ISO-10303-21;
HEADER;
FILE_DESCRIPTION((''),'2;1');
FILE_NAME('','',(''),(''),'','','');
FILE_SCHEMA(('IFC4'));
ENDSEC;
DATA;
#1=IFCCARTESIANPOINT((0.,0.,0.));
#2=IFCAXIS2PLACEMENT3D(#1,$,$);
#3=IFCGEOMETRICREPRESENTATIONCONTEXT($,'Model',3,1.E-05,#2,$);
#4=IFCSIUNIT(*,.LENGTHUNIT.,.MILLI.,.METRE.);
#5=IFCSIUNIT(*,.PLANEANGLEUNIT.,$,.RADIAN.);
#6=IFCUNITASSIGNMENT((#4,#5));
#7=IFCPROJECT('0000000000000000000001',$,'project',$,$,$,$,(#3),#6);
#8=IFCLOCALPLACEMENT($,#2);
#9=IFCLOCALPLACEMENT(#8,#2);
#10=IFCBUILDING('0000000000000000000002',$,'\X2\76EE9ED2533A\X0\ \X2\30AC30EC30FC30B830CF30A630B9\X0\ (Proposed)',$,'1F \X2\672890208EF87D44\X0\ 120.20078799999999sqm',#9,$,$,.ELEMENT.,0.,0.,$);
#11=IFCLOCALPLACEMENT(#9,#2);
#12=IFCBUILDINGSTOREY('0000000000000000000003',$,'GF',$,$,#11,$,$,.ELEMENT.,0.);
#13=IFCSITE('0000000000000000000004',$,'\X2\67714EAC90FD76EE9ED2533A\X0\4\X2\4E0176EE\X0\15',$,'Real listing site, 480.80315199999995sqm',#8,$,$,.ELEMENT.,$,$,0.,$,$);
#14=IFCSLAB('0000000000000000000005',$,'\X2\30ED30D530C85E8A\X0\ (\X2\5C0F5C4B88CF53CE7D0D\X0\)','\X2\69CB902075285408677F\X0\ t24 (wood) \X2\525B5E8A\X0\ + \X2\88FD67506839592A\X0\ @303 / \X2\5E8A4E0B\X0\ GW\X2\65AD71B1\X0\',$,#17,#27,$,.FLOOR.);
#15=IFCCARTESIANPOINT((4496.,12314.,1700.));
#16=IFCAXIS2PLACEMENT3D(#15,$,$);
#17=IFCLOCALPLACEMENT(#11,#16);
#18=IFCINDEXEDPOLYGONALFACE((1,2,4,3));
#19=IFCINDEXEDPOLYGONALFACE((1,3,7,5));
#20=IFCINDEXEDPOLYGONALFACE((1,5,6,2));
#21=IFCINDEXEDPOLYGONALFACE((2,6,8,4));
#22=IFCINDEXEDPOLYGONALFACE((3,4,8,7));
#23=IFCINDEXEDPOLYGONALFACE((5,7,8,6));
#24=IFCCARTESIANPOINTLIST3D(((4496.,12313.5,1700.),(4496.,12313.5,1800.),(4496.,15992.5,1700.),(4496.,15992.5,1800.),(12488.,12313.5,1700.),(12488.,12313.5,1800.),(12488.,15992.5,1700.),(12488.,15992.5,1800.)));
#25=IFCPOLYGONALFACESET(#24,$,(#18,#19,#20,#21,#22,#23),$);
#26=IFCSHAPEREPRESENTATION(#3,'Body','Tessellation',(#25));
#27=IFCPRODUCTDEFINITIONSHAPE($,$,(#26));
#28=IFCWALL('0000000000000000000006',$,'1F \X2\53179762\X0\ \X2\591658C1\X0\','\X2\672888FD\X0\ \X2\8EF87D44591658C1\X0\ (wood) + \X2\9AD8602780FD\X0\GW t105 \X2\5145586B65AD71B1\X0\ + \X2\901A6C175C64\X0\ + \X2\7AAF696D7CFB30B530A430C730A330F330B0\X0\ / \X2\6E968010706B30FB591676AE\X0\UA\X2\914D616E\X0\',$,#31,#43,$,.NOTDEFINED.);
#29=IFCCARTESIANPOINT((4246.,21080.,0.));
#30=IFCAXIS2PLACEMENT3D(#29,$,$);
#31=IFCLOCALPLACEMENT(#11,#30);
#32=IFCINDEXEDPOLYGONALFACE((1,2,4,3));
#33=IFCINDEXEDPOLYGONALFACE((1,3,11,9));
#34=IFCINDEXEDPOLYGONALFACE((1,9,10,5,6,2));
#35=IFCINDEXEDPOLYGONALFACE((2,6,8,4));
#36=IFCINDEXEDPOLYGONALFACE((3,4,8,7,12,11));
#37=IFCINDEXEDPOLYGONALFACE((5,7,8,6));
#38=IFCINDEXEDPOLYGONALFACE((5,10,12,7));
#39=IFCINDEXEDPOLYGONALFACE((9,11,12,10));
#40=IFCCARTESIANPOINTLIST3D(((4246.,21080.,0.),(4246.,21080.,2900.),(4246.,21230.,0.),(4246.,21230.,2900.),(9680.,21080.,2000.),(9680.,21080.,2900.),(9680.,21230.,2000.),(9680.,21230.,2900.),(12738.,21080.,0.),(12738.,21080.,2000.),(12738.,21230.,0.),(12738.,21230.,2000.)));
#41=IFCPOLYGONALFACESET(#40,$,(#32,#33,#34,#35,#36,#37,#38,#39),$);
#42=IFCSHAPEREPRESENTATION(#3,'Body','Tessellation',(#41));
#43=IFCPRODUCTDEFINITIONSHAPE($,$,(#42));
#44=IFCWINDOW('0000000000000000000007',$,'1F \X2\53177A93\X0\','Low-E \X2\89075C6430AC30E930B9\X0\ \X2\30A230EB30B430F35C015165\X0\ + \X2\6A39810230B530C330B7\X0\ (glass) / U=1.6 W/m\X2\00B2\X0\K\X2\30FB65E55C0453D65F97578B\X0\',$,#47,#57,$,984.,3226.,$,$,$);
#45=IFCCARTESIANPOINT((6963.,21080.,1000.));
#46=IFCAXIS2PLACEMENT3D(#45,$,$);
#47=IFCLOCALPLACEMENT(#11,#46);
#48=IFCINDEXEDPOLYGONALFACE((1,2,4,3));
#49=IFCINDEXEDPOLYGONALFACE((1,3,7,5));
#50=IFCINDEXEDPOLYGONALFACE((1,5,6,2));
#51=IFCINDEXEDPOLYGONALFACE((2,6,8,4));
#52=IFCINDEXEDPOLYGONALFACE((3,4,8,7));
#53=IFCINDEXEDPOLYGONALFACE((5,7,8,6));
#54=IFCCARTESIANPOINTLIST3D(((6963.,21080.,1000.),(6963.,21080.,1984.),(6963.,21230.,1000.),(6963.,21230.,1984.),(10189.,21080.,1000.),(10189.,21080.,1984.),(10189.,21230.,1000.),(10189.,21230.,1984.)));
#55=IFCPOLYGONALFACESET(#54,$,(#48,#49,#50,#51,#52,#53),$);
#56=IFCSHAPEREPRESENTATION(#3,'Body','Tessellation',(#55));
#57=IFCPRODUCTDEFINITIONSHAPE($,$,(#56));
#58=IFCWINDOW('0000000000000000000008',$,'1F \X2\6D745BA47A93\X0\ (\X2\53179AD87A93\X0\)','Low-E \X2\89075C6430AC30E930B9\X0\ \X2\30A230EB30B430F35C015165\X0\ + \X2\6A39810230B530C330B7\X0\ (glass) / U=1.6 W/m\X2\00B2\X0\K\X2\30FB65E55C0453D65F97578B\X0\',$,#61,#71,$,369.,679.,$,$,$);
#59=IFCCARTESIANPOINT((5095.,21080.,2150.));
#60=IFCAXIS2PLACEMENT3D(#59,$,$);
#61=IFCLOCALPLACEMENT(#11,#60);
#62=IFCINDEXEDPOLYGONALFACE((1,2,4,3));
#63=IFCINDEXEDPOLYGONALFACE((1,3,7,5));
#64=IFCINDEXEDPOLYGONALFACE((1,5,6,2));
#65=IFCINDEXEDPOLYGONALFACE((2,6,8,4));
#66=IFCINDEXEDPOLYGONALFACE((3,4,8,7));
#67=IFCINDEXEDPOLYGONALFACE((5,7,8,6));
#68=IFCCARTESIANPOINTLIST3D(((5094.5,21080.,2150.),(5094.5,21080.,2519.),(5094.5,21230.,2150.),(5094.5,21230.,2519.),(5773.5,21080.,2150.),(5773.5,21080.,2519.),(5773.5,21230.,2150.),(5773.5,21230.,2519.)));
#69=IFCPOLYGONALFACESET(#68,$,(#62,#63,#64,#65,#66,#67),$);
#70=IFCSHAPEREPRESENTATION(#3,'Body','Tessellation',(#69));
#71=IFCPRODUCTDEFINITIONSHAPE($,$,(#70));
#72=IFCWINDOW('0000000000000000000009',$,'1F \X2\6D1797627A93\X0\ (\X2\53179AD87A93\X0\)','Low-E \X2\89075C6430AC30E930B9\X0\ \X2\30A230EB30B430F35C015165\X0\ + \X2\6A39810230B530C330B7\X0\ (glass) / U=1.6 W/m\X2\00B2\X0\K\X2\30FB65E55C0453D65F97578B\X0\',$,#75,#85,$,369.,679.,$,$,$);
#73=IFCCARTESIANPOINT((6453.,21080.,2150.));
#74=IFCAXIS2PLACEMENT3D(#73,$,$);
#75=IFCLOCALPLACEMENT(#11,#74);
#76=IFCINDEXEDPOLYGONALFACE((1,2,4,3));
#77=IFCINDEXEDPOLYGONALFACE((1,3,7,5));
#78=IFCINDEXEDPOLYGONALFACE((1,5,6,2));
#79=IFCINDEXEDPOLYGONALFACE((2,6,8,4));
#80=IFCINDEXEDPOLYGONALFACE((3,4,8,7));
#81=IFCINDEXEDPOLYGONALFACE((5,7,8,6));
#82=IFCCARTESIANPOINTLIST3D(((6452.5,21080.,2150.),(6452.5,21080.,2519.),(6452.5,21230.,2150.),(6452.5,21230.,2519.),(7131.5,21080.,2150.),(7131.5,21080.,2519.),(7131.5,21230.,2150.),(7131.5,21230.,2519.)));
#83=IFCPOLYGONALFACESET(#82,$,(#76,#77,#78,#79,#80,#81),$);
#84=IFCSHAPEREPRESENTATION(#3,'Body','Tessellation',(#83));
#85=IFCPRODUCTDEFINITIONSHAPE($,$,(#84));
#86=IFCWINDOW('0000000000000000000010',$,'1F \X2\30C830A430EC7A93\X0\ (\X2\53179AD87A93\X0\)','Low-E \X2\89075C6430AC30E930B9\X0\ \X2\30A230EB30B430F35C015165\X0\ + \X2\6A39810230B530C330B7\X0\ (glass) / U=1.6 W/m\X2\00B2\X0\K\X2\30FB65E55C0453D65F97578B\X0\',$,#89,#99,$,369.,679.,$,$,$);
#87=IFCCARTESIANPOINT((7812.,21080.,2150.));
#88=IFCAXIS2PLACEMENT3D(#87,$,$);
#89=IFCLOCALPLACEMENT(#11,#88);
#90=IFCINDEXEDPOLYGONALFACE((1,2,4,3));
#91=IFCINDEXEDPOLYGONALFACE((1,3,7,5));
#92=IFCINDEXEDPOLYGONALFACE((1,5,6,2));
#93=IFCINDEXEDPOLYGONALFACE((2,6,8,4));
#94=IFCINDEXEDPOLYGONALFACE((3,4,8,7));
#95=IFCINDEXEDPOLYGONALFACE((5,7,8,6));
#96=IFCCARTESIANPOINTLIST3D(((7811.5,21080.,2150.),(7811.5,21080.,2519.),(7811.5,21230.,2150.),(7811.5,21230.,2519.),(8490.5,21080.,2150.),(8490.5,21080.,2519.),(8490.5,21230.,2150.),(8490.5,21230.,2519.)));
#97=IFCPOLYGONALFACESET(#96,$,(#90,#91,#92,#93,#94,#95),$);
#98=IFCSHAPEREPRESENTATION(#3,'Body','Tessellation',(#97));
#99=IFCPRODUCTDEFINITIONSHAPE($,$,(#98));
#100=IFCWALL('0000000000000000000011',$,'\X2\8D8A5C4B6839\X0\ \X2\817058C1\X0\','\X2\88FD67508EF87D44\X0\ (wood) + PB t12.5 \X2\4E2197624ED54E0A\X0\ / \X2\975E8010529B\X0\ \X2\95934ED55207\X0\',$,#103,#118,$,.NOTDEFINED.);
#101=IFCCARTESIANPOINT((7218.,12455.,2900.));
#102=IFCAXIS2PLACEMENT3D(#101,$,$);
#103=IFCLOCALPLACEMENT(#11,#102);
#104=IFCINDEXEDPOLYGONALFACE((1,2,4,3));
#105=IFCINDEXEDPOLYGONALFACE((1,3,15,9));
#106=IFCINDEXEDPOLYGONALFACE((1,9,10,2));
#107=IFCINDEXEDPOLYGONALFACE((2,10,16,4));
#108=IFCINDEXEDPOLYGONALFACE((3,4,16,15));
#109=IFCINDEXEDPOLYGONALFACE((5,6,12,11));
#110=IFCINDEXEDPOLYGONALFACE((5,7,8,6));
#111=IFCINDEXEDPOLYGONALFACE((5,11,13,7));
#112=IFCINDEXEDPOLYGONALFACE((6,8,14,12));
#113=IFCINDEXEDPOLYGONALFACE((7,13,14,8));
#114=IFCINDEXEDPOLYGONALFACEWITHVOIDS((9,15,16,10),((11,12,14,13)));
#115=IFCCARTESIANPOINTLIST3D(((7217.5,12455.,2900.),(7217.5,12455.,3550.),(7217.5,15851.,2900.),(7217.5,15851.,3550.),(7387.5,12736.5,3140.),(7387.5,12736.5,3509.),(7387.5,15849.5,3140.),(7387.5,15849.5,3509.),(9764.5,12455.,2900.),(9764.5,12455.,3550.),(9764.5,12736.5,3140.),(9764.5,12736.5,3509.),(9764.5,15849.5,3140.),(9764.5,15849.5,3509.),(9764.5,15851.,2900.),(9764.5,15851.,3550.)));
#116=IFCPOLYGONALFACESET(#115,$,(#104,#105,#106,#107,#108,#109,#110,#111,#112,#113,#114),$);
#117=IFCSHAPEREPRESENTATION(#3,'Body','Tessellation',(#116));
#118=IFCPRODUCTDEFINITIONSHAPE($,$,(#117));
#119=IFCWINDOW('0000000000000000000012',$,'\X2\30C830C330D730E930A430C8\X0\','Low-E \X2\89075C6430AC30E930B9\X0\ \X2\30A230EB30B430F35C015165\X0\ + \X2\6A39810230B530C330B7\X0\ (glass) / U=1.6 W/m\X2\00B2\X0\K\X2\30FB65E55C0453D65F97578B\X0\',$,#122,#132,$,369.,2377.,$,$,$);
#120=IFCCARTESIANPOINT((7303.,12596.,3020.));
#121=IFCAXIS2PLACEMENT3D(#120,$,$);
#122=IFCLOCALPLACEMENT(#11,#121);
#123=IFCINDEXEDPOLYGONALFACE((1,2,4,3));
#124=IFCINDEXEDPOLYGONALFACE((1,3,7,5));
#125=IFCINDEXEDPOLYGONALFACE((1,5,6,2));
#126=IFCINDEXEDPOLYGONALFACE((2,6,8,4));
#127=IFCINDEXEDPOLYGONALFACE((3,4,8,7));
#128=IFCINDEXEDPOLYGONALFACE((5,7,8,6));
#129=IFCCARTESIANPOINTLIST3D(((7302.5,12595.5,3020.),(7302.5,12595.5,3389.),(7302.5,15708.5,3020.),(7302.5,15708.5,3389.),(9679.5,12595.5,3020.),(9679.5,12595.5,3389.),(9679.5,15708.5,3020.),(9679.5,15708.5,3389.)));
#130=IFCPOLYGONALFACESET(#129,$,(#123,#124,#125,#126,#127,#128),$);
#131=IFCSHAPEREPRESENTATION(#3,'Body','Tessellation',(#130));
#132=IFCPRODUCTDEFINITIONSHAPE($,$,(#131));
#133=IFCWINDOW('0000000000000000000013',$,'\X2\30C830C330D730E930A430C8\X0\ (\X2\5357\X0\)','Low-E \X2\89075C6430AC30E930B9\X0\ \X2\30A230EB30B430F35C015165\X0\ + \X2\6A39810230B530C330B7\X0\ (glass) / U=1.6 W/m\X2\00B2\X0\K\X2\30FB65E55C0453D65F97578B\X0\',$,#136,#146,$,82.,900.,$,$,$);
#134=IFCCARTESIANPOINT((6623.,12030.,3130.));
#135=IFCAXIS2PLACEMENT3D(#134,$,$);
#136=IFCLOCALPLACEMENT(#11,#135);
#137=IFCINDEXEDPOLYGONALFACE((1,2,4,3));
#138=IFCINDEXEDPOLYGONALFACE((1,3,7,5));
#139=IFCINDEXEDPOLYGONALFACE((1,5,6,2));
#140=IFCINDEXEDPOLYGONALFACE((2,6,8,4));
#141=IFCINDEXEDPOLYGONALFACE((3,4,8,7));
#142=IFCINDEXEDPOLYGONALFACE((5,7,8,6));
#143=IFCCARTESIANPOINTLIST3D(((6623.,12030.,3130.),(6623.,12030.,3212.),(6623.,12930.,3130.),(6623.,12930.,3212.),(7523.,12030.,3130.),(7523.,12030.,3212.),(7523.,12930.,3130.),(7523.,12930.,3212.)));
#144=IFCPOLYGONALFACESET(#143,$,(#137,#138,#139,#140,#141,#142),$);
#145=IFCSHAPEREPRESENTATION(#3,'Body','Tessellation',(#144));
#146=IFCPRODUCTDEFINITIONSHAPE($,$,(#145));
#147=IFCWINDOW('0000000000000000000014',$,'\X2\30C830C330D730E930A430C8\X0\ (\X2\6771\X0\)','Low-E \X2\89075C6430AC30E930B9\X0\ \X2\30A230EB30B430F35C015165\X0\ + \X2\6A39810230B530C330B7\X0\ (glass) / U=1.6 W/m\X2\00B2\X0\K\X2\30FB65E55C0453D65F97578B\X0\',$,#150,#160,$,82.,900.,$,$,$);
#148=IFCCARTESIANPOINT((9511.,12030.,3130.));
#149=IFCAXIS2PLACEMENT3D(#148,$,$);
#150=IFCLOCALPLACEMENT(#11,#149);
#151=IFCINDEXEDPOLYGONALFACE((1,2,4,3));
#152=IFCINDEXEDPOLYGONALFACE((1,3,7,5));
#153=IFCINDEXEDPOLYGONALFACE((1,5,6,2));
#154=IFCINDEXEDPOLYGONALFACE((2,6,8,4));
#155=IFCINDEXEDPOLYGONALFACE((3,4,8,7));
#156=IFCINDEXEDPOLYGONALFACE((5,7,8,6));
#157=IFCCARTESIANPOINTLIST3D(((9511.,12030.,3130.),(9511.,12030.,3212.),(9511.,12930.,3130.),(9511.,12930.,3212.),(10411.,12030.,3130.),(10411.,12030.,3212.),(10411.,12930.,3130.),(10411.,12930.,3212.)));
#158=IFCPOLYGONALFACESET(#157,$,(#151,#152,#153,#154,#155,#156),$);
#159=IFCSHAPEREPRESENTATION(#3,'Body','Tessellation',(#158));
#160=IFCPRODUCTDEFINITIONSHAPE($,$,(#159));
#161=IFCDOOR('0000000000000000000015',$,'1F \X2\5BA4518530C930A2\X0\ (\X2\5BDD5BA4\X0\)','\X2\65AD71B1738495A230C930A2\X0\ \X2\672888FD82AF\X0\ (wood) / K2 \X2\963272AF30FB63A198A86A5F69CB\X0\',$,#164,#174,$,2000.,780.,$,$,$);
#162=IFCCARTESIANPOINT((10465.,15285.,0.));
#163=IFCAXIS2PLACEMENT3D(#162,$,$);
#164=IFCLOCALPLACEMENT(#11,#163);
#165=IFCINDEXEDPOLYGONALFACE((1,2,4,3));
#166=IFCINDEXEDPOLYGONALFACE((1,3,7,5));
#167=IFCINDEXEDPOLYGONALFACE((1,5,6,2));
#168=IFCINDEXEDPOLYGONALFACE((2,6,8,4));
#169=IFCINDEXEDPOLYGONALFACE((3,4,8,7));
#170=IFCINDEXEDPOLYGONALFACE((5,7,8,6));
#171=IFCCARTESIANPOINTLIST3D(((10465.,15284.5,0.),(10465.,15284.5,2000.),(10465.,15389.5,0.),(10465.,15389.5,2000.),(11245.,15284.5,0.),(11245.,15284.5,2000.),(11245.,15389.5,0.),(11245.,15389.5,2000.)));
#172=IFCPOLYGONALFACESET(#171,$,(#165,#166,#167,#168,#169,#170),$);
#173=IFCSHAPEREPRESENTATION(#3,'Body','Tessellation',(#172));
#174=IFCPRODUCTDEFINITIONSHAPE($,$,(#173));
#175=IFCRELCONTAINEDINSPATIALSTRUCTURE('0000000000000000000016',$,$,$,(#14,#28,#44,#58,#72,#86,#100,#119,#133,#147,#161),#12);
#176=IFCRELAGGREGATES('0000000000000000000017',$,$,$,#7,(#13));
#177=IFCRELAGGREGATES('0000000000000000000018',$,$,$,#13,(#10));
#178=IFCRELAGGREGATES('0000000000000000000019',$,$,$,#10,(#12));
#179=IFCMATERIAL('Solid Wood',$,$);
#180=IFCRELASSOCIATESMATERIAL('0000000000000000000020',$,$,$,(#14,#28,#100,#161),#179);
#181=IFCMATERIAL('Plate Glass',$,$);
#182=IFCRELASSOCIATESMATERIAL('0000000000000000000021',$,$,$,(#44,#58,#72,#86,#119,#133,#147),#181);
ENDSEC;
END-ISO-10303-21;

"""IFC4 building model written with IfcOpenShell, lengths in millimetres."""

from ifc_helpers import new_model, si_unit, frame, frame_2d, origin, place, context, project, spatial, rectangle, extrude, material, element, fill, save


model = new_model("IFC4")

# Units and contexts
model_context = context("Model", 3, precision=1e-05, world=origin())
ifc_project = project(units=[si_unit("LENGTHUNIT", "METRE", prefix="MILLI"), si_unit("PLANEANGLEUNIT", "RADIAN")], contexts=[model_context])

# Site, building, storey
site_placement = place(None, origin())
site = spatial("IfcSite", under=ifc_project, at=site_placement, Name="東京都目黒区4丁目15", ObjectType="Real listing site, 480.80315199999995sqm", CompositionType="ELEMENT", RefElevation=0.0)
building_placement = place(site_placement, origin())
building = spatial("IfcBuilding", under=site, at=building_placement, Name="目黒区 ガレージハウス (Proposed)", ObjectType="1F 木造軸組 120.20078799999999sqm", CompositionType="ELEMENT", ElevationOfRefHeight=0.0, ElevationOfTerrain=0.0)
storey_placement = place(building_placement, origin())
storey = spatial("IfcBuildingStorey", under=building, at=storey_placement, Name="GF", CompositionType="ELEMENT", Elevation=0.0)

# Slab
ifc_material_1 = material(Name="Solid Wood")
slab_placement = place(storey_placement, frame((4496.0, 12314.0, 1700.0)))
element("IfcSlab", 1, at=slab_placement, inside=storey, material=ifc_material_1, Name="ロフト床 (小屋裏収納)", Description="構造用合板 t24 (wood) 剛床 + 製材根太 @303 / 床下 GW断熱", PredefinedType="FLOOR", context=model_context, shape_type="SweptSolid", body=[
    extrude(rectangle(XDim=7992.0, YDim=3679.0, at=frame_2d((3996.0, 1839.0))), frame((4496.0, 12314.0, 1700.0)), (0.0, 0.0, 1.0), 100.0),
])

# Wall, openings, windows
wall_1_placement = place(storey_placement, frame((4246.0, 21080.0, 0.0)))
wall_1 = element("IfcWall", 2, at=wall_1_placement, inside=storey, material=ifc_material_1, Name="1F 北面 外壁", Description="木製 軸組外壁 (wood) + 高性能GW t105 充填断熱 + 通気層 + 窯業系サイディング / 準耐火・外皮UA配慮", PredefinedType="NOTDEFINED", context=model_context, shape_type="SweptSolid", body=[
    extrude(rectangle(XDim=8492.0, YDim=150.0, at=frame_2d((4246.0, 75.0))), frame((4246.0, 21080.0, 0.0)), (0.0, 0.0, 1.0), 2900.0),
])
opening_1_placement = place(storey_placement, frame((6963.0, 21080.0, 1000.0)))
opening_1 = element("IfcOpeningElement", 3, at=opening_1_placement, cuts=wall_1, PredefinedType="NOTDEFINED", context=model_context, shape_type="SweptSolid", body=[
    extrude(rectangle(XDim=3226.0, YDim=150.0, at=frame_2d((1613.0, 75.0))), frame((6963.0, 21080.0, 1000.0)), (0.0, 0.0, 1.0), 984.0),
])
opening_2_placement = place(storey_placement, frame((5095.0, 21080.0, 2150.0)))
opening_2 = element("IfcOpeningElement", 4, at=opening_2_placement, cuts=wall_1, PredefinedType="NOTDEFINED", context=model_context, shape_type="SweptSolid", body=[
    extrude(rectangle(XDim=679.0, YDim=150.0, at=frame_2d((339.0, 75.0))), frame((5095.0, 21080.0, 2150.0)), (0.0, 0.0, 1.0), 369.0),
])
opening_3_placement = place(storey_placement, frame((6453.0, 21080.0, 2150.0)))
opening_3 = element("IfcOpeningElement", 5, at=opening_3_placement, cuts=wall_1, PredefinedType="NOTDEFINED", context=model_context, shape_type="SweptSolid", body=[
    extrude(rectangle(XDim=679.0, YDim=150.0, at=frame_2d((339.0, 75.0))), frame((6453.0, 21080.0, 2150.0)), (0.0, 0.0, 1.0), 369.0),
])
opening_4_placement = place(storey_placement, frame((7812.0, 21080.0, 2150.0)))
opening_4 = element("IfcOpeningElement", 6, at=opening_4_placement, cuts=wall_1, PredefinedType="NOTDEFINED", context=model_context, shape_type="SweptSolid", body=[
    extrude(rectangle(XDim=679.0, YDim=150.0, at=frame_2d((339.0, 75.0))), frame((7812.0, 21080.0, 2150.0)), (0.0, 0.0, 1.0), 369.0),
])
ifc_material_2 = material(Name="Plate Glass")
window_1_placement = place(storey_placement, frame((6963.0, 21080.0, 1000.0)))
window_1 = element("IfcWindow", 7, at=window_1_placement, inside=storey, material=ifc_material_2, Name="1F 北窓", Description="Low-E 複層ガラス アルゴン封入 + 樹脂サッシ (glass) / U=1.6 W/m²K・日射取得型", OverallHeight=984.0, OverallWidth=3226.0, context=model_context, shape_type="SweptSolid", body=[
    extrude(rectangle(XDim=3226.0, YDim=150.0, at=frame_2d((1613.0, 75.0))), frame((6963.0, 21080.0, 1000.0)), (0.0, 0.0, 1.0), 984.0),
])
fill(opening_1, window_1)
window_2_placement = place(storey_placement, frame((5095.0, 21080.0, 2150.0)))
window_2 = element("IfcWindow", 8, at=window_2_placement, inside=storey, material=ifc_material_2, Name="1F 浴室窓 (北高窓)", Description="Low-E 複層ガラス アルゴン封入 + 樹脂サッシ (glass) / U=1.6 W/m²K・日射取得型", OverallHeight=369.0, OverallWidth=679.0, context=model_context, shape_type="SweptSolid", body=[
    extrude(rectangle(XDim=679.0, YDim=150.0, at=frame_2d((339.0, 75.0))), frame((5095.0, 21080.0, 2150.0)), (0.0, 0.0, 1.0), 369.0),
])
fill(opening_2, window_2)
window_3_placement = place(storey_placement, frame((6453.0, 21080.0, 2150.0)))
window_3 = element("IfcWindow", 9, at=window_3_placement, inside=storey, material=ifc_material_2, Name="1F 洗面窓 (北高窓)", Description="Low-E 複層ガラス アルゴン封入 + 樹脂サッシ (glass) / U=1.6 W/m²K・日射取得型", OverallHeight=369.0, OverallWidth=679.0, context=model_context, shape_type="SweptSolid", body=[
    extrude(rectangle(XDim=679.0, YDim=150.0, at=frame_2d((339.0, 75.0))), frame((6453.0, 21080.0, 2150.0)), (0.0, 0.0, 1.0), 369.0),
])
fill(opening_3, window_3)
window_4_placement = place(storey_placement, frame((7812.0, 21080.0, 2150.0)))
window_4 = element("IfcWindow", 10, at=window_4_placement, inside=storey, material=ifc_material_2, Name="1F トイレ窓 (北高窓)", Description="Low-E 複層ガラス アルゴン封入 + 樹脂サッシ (glass) / U=1.6 W/m²K・日射取得型", OverallHeight=369.0, OverallWidth=679.0, context=model_context, shape_type="SweptSolid", body=[
    extrude(rectangle(XDim=679.0, YDim=150.0, at=frame_2d((339.0, 75.0))), frame((7812.0, 21080.0, 2150.0)), (0.0, 0.0, 1.0), 369.0),
])
fill(opening_4, window_4)

# Wall, openings, windows
wall_2_placement = place(storey_placement, frame((7218.0, 12455.0, 2900.0)))
wall_2 = element("IfcWall", 11, at=wall_2_placement, inside=storey, material=ifc_material_1, Name="越屋根 腰壁", Description="製材軸組 (wood) + PB t12.5 両面仕上 / 非耐力 間仕切", PredefinedType="NOTDEFINED", context=model_context, shape_type="SweptSolid", body=[
    extrude(rectangle(XDim=2547.0, YDim=3396.0, at=frame_2d((1273.0, 1698.0))), frame((7218.0, 12455.0, 2900.0)), (0.0, 0.0, 1.0), 650.0),
])
opening_5_placement = place(storey_placement, frame((7303.0, 12596.0, 3020.0)))
opening_5 = element("IfcOpeningElement", 12, at=opening_5_placement, cuts=wall_2, PredefinedType="NOTDEFINED", context=model_context, shape_type="SweptSolid", body=[
    extrude(rectangle(XDim=2377.0, YDim=3113.0, at=frame_2d((1188.0, 1556.0))), frame((7303.0, 12596.0, 3020.0)), (0.0, 0.0, 1.0), 369.0),
])
opening_6_placement = place(storey_placement, frame((6623.0, 12030.0, 3130.0)))
opening_6 = element("IfcOpeningElement", 13, at=opening_6_placement, cuts=wall_2, PredefinedType="NOTDEFINED", context=model_context, shape_type="SweptSolid", body=[
    extrude(rectangle(XDim=900.0, YDim=900.0, at=frame_2d((450.0, 450.0))), frame((6623.0, 12030.0, 3130.0)), (0.0, 0.0, 1.0), 82.0),
])
opening_7_placement = place(storey_placement, frame((9511.0, 12030.0, 3130.0)))
opening_7 = element("IfcOpeningElement", 14, at=opening_7_placement, cuts=wall_2, PredefinedType="NOTDEFINED", context=model_context, shape_type="SweptSolid", body=[
    extrude(rectangle(XDim=900.0, YDim=900.0, at=frame_2d((450.0, 450.0))), frame((9511.0, 12030.0, 3130.0)), (0.0, 0.0, 1.0), 82.0),
])
window_5_placement = place(storey_placement, frame((7303.0, 12596.0, 3020.0)))
window_5 = element("IfcWindow", 15, at=window_5_placement, inside=storey, material=ifc_material_2, Name="トップライト", Description="Low-E 複層ガラス アルゴン封入 + 樹脂サッシ (glass) / U=1.6 W/m²K・日射取得型", OverallHeight=369.0, OverallWidth=2377.0, context=model_context, shape_type="SweptSolid", body=[
    extrude(rectangle(XDim=2377.0, YDim=3113.0, at=frame_2d((1188.0, 1556.0))), frame((7303.0, 12596.0, 3020.0)), (0.0, 0.0, 1.0), 369.0),
])
fill(opening_5, window_5)
window_6_placement = place(storey_placement, frame((6623.0, 12030.0, 3130.0)))
window_6 = element("IfcWindow", 16, at=window_6_placement, inside=storey, material=ifc_material_2, Name="トップライト (南)", Description="Low-E 複層ガラス アルゴン封入 + 樹脂サッシ (glass) / U=1.6 W/m²K・日射取得型", OverallHeight=82.0, OverallWidth=900.0, context=model_context, shape_type="SweptSolid", body=[
    extrude(rectangle(XDim=900.0, YDim=900.0, at=frame_2d((450.0, 450.0))), frame((6623.0, 12030.0, 3130.0)), (0.0, 0.0, 1.0), 82.0),
])
fill(opening_6, window_6)
window_7_placement = place(storey_placement, frame((9511.0, 12030.0, 3130.0)))
window_7 = element("IfcWindow", 17, at=window_7_placement, inside=storey, material=ifc_material_2, Name="トップライト (東)", Description="Low-E 複層ガラス アルゴン封入 + 樹脂サッシ (glass) / U=1.6 W/m²K・日射取得型", OverallHeight=82.0, OverallWidth=900.0, context=model_context, shape_type="SweptSolid", body=[
    extrude(rectangle(XDim=900.0, YDim=900.0, at=frame_2d((450.0, 450.0))), frame((9511.0, 12030.0, 3130.0)), (0.0, 0.0, 1.0), 82.0),
])
fill(opening_7, window_7)

# Door
door_1_placement = place(storey_placement, frame((10465.0, 15285.0, 0.0)))
element("IfcDoor", 18, at=door_1_placement, inside=storey, material=ifc_material_1, Name="1F 室内ドア (寝室)", Description="断熱玄関ドア 木製芯 (wood) / K2 防犯・採風機構", OverallHeight=2000.0, OverallWidth=780.0, context=model_context, shape_type="SweptSolid", body=[
    extrude(rectangle(XDim=780.0, YDim=105.0, at=frame_2d((390.0, 52.0))), frame((10465.0, 15285.0, 0.0)), (0.0, 0.0, 1.0), 2000.0),
])

save(model, "model.ifc")
